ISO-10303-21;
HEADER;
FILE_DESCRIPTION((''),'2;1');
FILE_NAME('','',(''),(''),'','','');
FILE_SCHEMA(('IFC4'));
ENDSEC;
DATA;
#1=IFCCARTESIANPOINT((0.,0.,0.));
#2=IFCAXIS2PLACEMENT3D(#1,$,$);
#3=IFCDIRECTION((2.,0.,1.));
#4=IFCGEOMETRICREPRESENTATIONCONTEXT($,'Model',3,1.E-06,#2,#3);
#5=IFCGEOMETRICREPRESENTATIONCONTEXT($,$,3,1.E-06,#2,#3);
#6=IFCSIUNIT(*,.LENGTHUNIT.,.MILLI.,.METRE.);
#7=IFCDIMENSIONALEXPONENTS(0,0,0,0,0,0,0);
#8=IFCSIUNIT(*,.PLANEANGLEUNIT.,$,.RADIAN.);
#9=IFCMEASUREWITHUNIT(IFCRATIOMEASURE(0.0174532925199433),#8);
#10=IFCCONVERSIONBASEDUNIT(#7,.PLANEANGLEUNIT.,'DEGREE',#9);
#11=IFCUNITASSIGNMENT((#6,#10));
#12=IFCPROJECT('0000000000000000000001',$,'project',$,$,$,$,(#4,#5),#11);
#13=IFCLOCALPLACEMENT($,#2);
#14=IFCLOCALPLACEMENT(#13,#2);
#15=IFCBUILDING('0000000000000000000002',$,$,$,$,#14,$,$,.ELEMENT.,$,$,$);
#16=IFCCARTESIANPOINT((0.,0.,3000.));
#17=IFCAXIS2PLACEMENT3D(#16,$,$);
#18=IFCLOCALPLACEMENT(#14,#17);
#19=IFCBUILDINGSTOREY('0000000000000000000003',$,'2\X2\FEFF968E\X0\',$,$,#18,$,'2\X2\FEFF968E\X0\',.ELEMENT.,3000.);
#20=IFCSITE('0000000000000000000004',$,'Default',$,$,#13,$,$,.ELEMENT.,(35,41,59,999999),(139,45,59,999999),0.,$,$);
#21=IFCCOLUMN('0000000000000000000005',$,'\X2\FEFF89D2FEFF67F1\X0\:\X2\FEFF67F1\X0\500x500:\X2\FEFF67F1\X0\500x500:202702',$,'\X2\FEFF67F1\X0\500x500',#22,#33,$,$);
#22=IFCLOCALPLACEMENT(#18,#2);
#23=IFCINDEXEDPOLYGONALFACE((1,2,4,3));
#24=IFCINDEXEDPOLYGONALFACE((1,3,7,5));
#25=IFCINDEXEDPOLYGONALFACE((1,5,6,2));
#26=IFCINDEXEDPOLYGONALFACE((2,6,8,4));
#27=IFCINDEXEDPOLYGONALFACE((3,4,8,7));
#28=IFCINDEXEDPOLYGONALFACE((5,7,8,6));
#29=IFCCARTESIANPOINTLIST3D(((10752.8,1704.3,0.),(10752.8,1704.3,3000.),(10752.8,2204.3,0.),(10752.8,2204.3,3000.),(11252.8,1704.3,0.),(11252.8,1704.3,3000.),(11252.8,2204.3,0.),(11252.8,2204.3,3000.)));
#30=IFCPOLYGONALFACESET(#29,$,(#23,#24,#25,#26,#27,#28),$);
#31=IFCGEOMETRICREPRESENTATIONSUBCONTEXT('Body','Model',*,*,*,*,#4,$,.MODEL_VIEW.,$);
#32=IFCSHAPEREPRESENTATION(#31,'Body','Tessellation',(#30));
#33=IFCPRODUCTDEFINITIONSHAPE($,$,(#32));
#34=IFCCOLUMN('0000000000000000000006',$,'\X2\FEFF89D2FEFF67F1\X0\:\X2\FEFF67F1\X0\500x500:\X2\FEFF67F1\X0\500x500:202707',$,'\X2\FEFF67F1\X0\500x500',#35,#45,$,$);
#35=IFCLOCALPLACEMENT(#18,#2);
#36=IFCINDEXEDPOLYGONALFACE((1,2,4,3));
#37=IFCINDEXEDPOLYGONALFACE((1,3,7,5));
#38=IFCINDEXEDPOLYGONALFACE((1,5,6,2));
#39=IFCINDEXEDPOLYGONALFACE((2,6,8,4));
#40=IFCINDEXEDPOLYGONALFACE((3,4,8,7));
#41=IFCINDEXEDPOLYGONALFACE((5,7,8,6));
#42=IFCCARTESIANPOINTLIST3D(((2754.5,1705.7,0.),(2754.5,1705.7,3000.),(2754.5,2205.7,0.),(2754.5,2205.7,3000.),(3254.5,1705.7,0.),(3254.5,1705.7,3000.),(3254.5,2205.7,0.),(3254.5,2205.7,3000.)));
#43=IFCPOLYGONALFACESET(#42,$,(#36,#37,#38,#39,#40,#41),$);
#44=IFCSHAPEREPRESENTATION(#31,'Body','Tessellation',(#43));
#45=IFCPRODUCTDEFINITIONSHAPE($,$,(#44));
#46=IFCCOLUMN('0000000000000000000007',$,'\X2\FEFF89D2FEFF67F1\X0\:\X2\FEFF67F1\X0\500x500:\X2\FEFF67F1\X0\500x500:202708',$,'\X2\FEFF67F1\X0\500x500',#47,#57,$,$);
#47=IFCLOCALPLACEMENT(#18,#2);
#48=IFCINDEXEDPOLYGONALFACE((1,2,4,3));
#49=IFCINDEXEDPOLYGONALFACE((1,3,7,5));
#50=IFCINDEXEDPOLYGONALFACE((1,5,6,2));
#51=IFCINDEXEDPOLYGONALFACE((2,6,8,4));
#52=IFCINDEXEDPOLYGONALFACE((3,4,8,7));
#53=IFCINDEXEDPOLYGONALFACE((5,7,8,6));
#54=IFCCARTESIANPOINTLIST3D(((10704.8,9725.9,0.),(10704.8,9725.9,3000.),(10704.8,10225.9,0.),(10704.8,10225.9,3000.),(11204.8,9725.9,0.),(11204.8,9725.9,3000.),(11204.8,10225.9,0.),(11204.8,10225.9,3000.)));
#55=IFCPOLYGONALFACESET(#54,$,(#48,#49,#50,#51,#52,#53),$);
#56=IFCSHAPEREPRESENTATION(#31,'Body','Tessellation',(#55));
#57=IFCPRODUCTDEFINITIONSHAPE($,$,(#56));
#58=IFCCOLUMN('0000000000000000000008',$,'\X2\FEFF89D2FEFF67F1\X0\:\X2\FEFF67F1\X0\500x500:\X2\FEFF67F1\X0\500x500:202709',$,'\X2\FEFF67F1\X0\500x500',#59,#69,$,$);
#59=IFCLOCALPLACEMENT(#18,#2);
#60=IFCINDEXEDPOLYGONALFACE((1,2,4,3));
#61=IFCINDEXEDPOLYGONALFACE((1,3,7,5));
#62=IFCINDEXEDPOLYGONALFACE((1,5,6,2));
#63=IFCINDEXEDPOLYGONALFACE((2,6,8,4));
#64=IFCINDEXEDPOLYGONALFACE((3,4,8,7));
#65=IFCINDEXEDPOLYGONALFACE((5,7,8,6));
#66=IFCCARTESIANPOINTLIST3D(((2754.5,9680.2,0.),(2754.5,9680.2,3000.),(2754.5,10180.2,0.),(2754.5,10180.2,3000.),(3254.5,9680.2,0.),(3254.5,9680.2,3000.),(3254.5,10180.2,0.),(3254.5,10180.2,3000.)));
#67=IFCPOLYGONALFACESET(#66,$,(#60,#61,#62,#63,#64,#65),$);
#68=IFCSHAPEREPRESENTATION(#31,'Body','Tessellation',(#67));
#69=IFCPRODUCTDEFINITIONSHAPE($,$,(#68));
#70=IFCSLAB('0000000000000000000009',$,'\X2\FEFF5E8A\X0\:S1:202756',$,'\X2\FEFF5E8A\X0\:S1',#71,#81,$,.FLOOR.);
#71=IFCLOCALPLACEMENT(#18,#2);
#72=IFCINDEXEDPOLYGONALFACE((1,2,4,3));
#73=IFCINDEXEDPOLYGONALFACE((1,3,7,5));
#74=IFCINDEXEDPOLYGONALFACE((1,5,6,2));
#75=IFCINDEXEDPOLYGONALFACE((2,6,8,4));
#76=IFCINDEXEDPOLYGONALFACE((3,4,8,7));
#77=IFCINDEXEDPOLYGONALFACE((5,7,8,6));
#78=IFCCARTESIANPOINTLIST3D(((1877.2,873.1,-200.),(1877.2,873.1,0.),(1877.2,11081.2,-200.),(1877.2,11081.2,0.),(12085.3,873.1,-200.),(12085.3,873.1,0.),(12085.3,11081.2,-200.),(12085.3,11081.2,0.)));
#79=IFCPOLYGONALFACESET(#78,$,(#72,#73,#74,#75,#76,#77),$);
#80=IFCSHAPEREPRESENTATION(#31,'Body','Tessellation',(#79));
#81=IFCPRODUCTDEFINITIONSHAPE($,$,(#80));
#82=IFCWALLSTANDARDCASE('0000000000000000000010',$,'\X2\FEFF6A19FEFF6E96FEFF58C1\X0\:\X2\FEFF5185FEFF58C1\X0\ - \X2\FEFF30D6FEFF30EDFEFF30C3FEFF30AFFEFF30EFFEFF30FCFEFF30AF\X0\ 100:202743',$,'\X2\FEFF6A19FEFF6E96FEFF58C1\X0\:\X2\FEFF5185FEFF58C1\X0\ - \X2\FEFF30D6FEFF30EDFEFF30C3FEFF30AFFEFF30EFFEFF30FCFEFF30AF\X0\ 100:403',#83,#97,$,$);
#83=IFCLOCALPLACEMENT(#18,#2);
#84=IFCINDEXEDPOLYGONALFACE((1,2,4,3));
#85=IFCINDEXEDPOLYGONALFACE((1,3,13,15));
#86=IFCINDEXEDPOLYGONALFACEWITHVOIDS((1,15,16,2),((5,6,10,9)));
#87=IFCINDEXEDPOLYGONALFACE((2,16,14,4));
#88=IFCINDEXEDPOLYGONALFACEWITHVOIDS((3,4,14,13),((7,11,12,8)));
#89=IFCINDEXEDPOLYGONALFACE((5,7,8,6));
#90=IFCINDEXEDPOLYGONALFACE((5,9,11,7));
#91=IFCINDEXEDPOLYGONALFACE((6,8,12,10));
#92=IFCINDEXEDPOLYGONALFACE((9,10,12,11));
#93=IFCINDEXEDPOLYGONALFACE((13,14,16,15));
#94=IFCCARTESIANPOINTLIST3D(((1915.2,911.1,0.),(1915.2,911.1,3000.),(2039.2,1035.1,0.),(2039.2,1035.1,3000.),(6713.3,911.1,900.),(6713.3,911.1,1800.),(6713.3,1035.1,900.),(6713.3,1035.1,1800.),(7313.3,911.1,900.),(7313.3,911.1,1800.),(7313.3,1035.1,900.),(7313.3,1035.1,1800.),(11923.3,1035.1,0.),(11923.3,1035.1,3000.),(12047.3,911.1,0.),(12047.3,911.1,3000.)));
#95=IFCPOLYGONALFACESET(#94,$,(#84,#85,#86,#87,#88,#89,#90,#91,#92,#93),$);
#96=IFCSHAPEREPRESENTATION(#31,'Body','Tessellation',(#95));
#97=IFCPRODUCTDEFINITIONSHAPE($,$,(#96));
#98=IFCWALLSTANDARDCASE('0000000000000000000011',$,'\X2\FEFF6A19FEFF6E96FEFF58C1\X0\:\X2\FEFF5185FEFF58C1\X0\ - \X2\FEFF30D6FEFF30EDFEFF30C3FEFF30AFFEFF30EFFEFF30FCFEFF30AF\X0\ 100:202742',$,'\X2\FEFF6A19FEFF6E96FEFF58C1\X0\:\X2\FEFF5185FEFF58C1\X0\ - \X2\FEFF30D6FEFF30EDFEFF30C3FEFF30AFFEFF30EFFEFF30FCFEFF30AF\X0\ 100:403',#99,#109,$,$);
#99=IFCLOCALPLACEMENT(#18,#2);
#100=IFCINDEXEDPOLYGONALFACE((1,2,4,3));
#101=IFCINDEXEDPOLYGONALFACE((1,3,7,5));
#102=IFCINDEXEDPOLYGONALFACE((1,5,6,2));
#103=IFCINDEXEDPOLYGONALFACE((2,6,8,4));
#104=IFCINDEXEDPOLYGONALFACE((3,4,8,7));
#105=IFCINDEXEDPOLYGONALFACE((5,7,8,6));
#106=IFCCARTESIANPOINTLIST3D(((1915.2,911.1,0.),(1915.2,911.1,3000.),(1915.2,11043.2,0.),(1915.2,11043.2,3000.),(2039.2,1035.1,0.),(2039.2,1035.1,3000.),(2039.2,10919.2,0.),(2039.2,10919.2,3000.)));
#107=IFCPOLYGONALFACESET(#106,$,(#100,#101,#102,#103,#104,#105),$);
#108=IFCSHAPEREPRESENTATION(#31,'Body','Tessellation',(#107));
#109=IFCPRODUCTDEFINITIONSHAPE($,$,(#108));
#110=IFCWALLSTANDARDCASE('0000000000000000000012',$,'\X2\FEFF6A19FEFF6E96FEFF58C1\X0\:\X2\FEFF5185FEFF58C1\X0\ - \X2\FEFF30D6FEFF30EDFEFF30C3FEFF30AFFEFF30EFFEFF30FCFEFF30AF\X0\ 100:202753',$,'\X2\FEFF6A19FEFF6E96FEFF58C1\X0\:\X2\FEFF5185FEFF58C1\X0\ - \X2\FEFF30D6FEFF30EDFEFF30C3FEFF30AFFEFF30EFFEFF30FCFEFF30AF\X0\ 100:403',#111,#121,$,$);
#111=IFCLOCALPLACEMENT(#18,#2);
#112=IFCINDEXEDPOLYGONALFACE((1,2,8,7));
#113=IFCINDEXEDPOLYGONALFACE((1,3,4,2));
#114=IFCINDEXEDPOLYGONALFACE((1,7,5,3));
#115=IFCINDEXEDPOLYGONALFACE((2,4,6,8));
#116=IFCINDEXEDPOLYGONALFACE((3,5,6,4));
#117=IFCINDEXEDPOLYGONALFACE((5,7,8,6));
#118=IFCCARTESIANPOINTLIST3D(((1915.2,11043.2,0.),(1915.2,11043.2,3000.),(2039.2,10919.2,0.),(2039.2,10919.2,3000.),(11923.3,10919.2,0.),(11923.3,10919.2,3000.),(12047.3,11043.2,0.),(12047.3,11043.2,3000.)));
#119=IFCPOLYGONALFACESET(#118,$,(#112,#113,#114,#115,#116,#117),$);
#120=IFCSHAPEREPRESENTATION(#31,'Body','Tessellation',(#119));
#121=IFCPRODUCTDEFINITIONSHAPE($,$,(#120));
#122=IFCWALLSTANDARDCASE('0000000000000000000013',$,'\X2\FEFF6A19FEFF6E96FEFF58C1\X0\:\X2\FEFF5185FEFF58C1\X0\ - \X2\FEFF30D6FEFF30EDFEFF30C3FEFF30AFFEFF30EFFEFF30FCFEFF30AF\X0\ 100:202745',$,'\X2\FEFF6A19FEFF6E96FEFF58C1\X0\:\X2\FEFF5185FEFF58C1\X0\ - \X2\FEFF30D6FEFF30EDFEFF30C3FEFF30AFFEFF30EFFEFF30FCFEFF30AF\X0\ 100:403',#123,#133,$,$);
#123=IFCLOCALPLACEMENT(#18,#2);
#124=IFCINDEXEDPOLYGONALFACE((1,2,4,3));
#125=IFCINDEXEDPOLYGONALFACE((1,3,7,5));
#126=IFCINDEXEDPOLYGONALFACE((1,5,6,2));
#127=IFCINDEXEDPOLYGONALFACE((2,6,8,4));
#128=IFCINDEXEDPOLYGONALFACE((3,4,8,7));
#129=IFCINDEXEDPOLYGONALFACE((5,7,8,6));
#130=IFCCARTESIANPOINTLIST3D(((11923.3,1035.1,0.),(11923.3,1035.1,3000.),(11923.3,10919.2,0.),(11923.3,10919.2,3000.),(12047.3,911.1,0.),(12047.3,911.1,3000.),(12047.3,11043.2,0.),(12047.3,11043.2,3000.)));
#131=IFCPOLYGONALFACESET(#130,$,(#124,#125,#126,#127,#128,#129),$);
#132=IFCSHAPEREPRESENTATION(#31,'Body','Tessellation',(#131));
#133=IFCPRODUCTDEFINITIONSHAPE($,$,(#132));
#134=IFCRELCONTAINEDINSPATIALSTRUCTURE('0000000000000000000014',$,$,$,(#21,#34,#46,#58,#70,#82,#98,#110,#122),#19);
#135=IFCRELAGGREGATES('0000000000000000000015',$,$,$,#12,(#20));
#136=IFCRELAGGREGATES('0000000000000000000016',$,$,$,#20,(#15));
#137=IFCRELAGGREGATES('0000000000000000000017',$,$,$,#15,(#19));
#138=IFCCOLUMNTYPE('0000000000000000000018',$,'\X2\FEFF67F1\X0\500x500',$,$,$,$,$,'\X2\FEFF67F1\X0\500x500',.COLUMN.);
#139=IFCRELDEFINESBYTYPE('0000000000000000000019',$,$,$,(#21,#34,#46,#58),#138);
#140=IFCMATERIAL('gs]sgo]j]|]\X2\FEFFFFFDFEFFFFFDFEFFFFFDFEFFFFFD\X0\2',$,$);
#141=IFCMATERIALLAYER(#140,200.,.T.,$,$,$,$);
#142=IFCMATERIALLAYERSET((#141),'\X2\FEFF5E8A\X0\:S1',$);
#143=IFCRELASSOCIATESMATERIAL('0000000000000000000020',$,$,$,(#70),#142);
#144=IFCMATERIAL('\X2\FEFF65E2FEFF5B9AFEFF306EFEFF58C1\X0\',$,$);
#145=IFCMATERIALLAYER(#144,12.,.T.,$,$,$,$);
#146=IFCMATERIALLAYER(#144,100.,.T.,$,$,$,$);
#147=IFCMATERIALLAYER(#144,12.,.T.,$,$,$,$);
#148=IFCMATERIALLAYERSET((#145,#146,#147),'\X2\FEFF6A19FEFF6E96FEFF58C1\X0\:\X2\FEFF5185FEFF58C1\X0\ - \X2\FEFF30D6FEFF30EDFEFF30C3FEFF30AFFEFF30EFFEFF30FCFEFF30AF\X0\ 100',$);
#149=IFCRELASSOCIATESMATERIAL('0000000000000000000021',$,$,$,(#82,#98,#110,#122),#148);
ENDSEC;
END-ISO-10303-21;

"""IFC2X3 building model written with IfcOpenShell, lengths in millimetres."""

from ifc_helpers import new_model, entity, si_unit, converted_unit, direction, frame, frame_2d, origin, place, context, subcontext, project, spatial, polyline, rectangle, outline, extrude, source, transform, mapped, material, layer, layer_set, layer_usage, type_object, type_shapes, element, save


model = new_model("IFC2X3")

# Units and contexts
model_context = context("Model", 3, precision=1e-06, world=origin(), true_north=direction((2.0, 0.0, 1.0)))
context_of_model = context(None, 3, precision=1e-06, world=origin(), true_north=direction((2.0, 0.0, 1.0)))
body_context = subcontext(model_context, "Body", "Model", "MODEL_VIEW")
ifc_project = project(units=[si_unit("LENGTHUNIT", "METRE", prefix="MILLI"), converted_unit("PLANEANGLEUNIT", "DEGREE", entity("IfcRatioMeasure", 0.0174532925199433), si_unit("PLANEANGLEUNIT", "RADIAN"), dimensions=[0, 0, 0, 0, 0, 0, 0])], contexts=[model_context, context_of_model])

# Site, building, storey
site_placement = place(None, origin())
site = spatial("IfcSite", under=ifc_project, at=site_placement, Name="Default", CompositionType="ELEMENT", RefLatitude=(35, 41, 59, 999999), RefLongitude=(139, 45, 59, 999999), RefElevation=0.0)
building_placement = place(site_placement, origin())
building = spatial("IfcBuilding", under=site, at=building_placement, CompositionType="ELEMENT")
storey_placement = place(building_placement, frame((0.0, 0.0, 3000.0)))
storey = spatial("IfcBuildingStorey", under=building, at=storey_placement, Name="2\ufeff階", LongName="2\ufeff階", CompositionType="ELEMENT", Elevation=3000.0)

# Columns
column_type = type_object("IfcColumnType", Name="\ufeff柱500x500", ElementType="\ufeff柱500x500", PredefinedType="COLUMN")
shared_shape = source(origin(), body_context, "Body", "SweptSolid", [
    extrude(rectangle(XDim=500.0, YDim=500.0, at=frame_2d((0.0, 0.0), x_axis=(0.0, -1.0))), origin(), (0.0, 0.0, 1.0), 3000.0),
])
type_shapes(column_type, [shared_shape])
for number, where, name in (
    (1, (11002.8, 1954.3, 0.0), "\ufeff角\ufeff柱:\ufeff柱500x500:\ufeff柱500x500:202702"),
    (2, (3004.5, 1955.7, 0.0), "\ufeff角\ufeff柱:\ufeff柱500x500:\ufeff柱500x500:202707"),
    (3, (10954.8, 9975.9, 0.0), "\ufeff角\ufeff柱:\ufeff柱500x500:\ufeff柱500x500:202708"),
    (4, (3004.5, 9930.2, 0.0), "\ufeff角\ufeff柱:\ufeff柱500x500:\ufeff柱500x500:202709"),
):
    element("IfcColumn", number, at=place(storey_placement, frame(where)), inside=storey, type_object=column_type, Name=name, ObjectType="\ufeff柱500x500", context=body_context, shape_type="MappedRepresentation", body=[
        mapped(shared_shape, transform((0.0, 0.0, 0.0), scale=1.0)),
    ])

# Slab
ifc_material_1 = material(Name="gs]sgo]j]|]\ufeff�\ufeff�\ufeff�\ufeff�2")
ifc_layer_1 = layer(ifc_material_1, 200.0, ventilated=True)
ifc_layer_set_1 = layer_set([ifc_layer_1], Name="\ufeff床:S1")
ifc_layer_usage_1 = layer_usage(ifc_layer_set_1, "AXIS3", "POSITIVE", 0.0)
slab_1_placement = place(storey_placement, frame((1877.2, 873.1, -200.0)))
element("IfcSlab", 5, at=slab_1_placement, inside=storey, material=ifc_layer_usage_1, Name="\ufeff床:S1:202756", ObjectType="\ufeff床:S1", PredefinedType="FLOOR", context=body_context, shape_type="SweptSolid", body=[
    extrude(rectangle(XDim=10208.1, YDim=10208.1, at=frame_2d((0.0, 0.0), x_axis=(0.0, -1.0))), frame((5104.0, 5104.0, 200.0), z_axis=(0.0, 0.0, -1.0), x_axis=(-1.0, 0.0, 0.0)), (0.0, 0.0, 1.0), 200.0),
])

# Wall, opening
ifc_material_2 = material(Name="\ufeff既\ufeff定\ufeffの\ufeff壁")
ifc_layer_2 = layer(ifc_material_2, 12.0, ventilated=True)
ifc_layer_3 = layer(ifc_material_2, 100.0, ventilated=True)
ifc_layer_4 = layer(ifc_material_2, 12.0, ventilated=True)
ifc_layer_set_2 = layer_set([ifc_layer_2, ifc_layer_3, ifc_layer_4], Name="\ufeff標\ufeff準\ufeff壁:\ufeff内\ufeff壁 - \ufeffブ\ufeffロ\ufeffッ\ufeffク\ufeffワ\ufeffー\ufeffク 100")
ifc_layer_usage_2 = layer_usage(ifc_layer_set_2, "AXIS2", "NEGATIVE", 62.0)
wall_1_placement = place(storey_placement, frame((1915.2, 973.1, 0.0)))
wall_1 = element("IfcWallStandardCase", 6, at=wall_1_placement, inside=storey, material=ifc_layer_usage_2, Name="\ufeff標\ufeff準\ufeff壁:\ufeff内\ufeff壁 - \ufeffブ\ufeffロ\ufeffッ\ufeffク\ufeffワ\ufeffー\ufeffク 100:202743", ObjectType="\ufeff標\ufeff準\ufeff壁:\ufeff内\ufeff壁 - \ufeffブ\ufeffロ\ufeffッ\ufeffク\ufeffワ\ufeffー\ufeffク 100:403", context=body_context, shape_type="SweptSolid", body=[
    extrude(outline(polyline([(10132.1, -62.0), (10008.1, 62.0), (124.0, 62.0), (0.0, -62.0), (10132.1, -62.0)])), origin(), (0.0, 0.0, 1.0), 3000.0),
])
opening_placement = place(wall_1_placement, frame((4798.0, -62.0, 900.0)))
element("IfcOpeningElement", 7, at=opening_placement, cuts=wall_1, ObjectType="Opening", context=body_context, shape_type="SweptSolid", body=[
    extrude(rectangle(XDim=900.0, YDim=600.0, at=frame_2d((450.0, 300.0), x_axis=(1.0, 0.0))), frame((0.0, 0.0, 0.0), z_axis=(0.0, 1.0, 0.0), x_axis=(0.0, 0.0, 1.0)), (0.0, 0.0, 1.0), 124.0),
])

# Walls
ifc_layer_usage_3 = layer_usage(ifc_layer_set_2, "AXIS2", "NEGATIVE", 62.0)
wall_2_placement = place(storey_placement, frame((1977.2, 11043.2, 0.0), z_axis=(0.0, 0.0, 1.0), x_axis=(0.0, -1.0, 0.0)))
element("IfcWallStandardCase", 8, at=wall_2_placement, inside=storey, material=ifc_layer_usage_3, Name="\ufeff標\ufeff準\ufeff壁:\ufeff内\ufeff壁 - \ufeffブ\ufeffロ\ufeffッ\ufeffク\ufeffワ\ufeffー\ufeffク 100:202742", ObjectType="\ufeff標\ufeff準\ufeff壁:\ufeff内\ufeff壁 - \ufeffブ\ufeffロ\ufeffッ\ufeffク\ufeffワ\ufeffー\ufeffク 100:403", context=body_context, shape_type="SweptSolid", body=[
    extrude(outline(polyline([(10132.1, -62.0), (10008.1, 62.0), (124.0, 62.0), (0.0, -62.0), (10132.1, -62.0)])), origin(), (0.0, 0.0, 1.0), 3000.0),
])
ifc_layer_usage_4 = layer_usage(ifc_layer_set_2, "AXIS2", "NEGATIVE", 62.0)
wall_3_placement = place(storey_placement, frame((12047.3, 10981.2, 0.0), z_axis=(0.0, 0.0, 1.0), x_axis=(-1.0, 0.0, 0.0)))
element("IfcWallStandardCase", 9, at=wall_3_placement, inside=storey, material=ifc_layer_usage_4, Name="\ufeff標\ufeff準\ufeff壁:\ufeff内\ufeff壁 - \ufeffブ\ufeffロ\ufeffッ\ufeffク\ufeffワ\ufeffー\ufeffク 100:202753", ObjectType="\ufeff標\ufeff準\ufeff壁:\ufeff内\ufeff壁 - \ufeffブ\ufeffロ\ufeffッ\ufeffク\ufeffワ\ufeffー\ufeffク 100:403", context=body_context, shape_type="SweptSolid", body=[
    extrude(outline(polyline([(10132.1, -62.0), (10008.1, 62.0), (124.0, 62.0), (0.0, -62.0), (10132.1, -62.0)])), origin(), (0.0, 0.0, 1.0), 3000.0),
])
ifc_layer_usage_5 = layer_usage(ifc_layer_set_2, "AXIS2", "NEGATIVE", 62.0)
wall_4_placement = place(storey_placement, frame((11985.3, 911.1, 0.0), z_axis=(0.0, 0.0, 1.0), x_axis=(0.0, 1.0, 0.0)))
element("IfcWallStandardCase", 10, at=wall_4_placement, inside=storey, material=ifc_layer_usage_5, Name="\ufeff標\ufeff準\ufeff壁:\ufeff内\ufeff壁 - \ufeffブ\ufeffロ\ufeffッ\ufeffク\ufeffワ\ufeffー\ufeffク 100:202745", ObjectType="\ufeff標\ufeff準\ufeff壁:\ufeff内\ufeff壁 - \ufeffブ\ufeffロ\ufeffッ\ufeffク\ufeffワ\ufeffー\ufeffク 100:403", context=body_context, shape_type="SweptSolid", body=[
    extrude(outline(polyline([(10132.1, -62.0), (10008.1, 62.0), (124.0, 62.0), (0.0, -62.0), (10132.1, -62.0)])), origin(), (0.0, 0.0, 1.0), 3000.0),
])

save(model, "model.ifc")
